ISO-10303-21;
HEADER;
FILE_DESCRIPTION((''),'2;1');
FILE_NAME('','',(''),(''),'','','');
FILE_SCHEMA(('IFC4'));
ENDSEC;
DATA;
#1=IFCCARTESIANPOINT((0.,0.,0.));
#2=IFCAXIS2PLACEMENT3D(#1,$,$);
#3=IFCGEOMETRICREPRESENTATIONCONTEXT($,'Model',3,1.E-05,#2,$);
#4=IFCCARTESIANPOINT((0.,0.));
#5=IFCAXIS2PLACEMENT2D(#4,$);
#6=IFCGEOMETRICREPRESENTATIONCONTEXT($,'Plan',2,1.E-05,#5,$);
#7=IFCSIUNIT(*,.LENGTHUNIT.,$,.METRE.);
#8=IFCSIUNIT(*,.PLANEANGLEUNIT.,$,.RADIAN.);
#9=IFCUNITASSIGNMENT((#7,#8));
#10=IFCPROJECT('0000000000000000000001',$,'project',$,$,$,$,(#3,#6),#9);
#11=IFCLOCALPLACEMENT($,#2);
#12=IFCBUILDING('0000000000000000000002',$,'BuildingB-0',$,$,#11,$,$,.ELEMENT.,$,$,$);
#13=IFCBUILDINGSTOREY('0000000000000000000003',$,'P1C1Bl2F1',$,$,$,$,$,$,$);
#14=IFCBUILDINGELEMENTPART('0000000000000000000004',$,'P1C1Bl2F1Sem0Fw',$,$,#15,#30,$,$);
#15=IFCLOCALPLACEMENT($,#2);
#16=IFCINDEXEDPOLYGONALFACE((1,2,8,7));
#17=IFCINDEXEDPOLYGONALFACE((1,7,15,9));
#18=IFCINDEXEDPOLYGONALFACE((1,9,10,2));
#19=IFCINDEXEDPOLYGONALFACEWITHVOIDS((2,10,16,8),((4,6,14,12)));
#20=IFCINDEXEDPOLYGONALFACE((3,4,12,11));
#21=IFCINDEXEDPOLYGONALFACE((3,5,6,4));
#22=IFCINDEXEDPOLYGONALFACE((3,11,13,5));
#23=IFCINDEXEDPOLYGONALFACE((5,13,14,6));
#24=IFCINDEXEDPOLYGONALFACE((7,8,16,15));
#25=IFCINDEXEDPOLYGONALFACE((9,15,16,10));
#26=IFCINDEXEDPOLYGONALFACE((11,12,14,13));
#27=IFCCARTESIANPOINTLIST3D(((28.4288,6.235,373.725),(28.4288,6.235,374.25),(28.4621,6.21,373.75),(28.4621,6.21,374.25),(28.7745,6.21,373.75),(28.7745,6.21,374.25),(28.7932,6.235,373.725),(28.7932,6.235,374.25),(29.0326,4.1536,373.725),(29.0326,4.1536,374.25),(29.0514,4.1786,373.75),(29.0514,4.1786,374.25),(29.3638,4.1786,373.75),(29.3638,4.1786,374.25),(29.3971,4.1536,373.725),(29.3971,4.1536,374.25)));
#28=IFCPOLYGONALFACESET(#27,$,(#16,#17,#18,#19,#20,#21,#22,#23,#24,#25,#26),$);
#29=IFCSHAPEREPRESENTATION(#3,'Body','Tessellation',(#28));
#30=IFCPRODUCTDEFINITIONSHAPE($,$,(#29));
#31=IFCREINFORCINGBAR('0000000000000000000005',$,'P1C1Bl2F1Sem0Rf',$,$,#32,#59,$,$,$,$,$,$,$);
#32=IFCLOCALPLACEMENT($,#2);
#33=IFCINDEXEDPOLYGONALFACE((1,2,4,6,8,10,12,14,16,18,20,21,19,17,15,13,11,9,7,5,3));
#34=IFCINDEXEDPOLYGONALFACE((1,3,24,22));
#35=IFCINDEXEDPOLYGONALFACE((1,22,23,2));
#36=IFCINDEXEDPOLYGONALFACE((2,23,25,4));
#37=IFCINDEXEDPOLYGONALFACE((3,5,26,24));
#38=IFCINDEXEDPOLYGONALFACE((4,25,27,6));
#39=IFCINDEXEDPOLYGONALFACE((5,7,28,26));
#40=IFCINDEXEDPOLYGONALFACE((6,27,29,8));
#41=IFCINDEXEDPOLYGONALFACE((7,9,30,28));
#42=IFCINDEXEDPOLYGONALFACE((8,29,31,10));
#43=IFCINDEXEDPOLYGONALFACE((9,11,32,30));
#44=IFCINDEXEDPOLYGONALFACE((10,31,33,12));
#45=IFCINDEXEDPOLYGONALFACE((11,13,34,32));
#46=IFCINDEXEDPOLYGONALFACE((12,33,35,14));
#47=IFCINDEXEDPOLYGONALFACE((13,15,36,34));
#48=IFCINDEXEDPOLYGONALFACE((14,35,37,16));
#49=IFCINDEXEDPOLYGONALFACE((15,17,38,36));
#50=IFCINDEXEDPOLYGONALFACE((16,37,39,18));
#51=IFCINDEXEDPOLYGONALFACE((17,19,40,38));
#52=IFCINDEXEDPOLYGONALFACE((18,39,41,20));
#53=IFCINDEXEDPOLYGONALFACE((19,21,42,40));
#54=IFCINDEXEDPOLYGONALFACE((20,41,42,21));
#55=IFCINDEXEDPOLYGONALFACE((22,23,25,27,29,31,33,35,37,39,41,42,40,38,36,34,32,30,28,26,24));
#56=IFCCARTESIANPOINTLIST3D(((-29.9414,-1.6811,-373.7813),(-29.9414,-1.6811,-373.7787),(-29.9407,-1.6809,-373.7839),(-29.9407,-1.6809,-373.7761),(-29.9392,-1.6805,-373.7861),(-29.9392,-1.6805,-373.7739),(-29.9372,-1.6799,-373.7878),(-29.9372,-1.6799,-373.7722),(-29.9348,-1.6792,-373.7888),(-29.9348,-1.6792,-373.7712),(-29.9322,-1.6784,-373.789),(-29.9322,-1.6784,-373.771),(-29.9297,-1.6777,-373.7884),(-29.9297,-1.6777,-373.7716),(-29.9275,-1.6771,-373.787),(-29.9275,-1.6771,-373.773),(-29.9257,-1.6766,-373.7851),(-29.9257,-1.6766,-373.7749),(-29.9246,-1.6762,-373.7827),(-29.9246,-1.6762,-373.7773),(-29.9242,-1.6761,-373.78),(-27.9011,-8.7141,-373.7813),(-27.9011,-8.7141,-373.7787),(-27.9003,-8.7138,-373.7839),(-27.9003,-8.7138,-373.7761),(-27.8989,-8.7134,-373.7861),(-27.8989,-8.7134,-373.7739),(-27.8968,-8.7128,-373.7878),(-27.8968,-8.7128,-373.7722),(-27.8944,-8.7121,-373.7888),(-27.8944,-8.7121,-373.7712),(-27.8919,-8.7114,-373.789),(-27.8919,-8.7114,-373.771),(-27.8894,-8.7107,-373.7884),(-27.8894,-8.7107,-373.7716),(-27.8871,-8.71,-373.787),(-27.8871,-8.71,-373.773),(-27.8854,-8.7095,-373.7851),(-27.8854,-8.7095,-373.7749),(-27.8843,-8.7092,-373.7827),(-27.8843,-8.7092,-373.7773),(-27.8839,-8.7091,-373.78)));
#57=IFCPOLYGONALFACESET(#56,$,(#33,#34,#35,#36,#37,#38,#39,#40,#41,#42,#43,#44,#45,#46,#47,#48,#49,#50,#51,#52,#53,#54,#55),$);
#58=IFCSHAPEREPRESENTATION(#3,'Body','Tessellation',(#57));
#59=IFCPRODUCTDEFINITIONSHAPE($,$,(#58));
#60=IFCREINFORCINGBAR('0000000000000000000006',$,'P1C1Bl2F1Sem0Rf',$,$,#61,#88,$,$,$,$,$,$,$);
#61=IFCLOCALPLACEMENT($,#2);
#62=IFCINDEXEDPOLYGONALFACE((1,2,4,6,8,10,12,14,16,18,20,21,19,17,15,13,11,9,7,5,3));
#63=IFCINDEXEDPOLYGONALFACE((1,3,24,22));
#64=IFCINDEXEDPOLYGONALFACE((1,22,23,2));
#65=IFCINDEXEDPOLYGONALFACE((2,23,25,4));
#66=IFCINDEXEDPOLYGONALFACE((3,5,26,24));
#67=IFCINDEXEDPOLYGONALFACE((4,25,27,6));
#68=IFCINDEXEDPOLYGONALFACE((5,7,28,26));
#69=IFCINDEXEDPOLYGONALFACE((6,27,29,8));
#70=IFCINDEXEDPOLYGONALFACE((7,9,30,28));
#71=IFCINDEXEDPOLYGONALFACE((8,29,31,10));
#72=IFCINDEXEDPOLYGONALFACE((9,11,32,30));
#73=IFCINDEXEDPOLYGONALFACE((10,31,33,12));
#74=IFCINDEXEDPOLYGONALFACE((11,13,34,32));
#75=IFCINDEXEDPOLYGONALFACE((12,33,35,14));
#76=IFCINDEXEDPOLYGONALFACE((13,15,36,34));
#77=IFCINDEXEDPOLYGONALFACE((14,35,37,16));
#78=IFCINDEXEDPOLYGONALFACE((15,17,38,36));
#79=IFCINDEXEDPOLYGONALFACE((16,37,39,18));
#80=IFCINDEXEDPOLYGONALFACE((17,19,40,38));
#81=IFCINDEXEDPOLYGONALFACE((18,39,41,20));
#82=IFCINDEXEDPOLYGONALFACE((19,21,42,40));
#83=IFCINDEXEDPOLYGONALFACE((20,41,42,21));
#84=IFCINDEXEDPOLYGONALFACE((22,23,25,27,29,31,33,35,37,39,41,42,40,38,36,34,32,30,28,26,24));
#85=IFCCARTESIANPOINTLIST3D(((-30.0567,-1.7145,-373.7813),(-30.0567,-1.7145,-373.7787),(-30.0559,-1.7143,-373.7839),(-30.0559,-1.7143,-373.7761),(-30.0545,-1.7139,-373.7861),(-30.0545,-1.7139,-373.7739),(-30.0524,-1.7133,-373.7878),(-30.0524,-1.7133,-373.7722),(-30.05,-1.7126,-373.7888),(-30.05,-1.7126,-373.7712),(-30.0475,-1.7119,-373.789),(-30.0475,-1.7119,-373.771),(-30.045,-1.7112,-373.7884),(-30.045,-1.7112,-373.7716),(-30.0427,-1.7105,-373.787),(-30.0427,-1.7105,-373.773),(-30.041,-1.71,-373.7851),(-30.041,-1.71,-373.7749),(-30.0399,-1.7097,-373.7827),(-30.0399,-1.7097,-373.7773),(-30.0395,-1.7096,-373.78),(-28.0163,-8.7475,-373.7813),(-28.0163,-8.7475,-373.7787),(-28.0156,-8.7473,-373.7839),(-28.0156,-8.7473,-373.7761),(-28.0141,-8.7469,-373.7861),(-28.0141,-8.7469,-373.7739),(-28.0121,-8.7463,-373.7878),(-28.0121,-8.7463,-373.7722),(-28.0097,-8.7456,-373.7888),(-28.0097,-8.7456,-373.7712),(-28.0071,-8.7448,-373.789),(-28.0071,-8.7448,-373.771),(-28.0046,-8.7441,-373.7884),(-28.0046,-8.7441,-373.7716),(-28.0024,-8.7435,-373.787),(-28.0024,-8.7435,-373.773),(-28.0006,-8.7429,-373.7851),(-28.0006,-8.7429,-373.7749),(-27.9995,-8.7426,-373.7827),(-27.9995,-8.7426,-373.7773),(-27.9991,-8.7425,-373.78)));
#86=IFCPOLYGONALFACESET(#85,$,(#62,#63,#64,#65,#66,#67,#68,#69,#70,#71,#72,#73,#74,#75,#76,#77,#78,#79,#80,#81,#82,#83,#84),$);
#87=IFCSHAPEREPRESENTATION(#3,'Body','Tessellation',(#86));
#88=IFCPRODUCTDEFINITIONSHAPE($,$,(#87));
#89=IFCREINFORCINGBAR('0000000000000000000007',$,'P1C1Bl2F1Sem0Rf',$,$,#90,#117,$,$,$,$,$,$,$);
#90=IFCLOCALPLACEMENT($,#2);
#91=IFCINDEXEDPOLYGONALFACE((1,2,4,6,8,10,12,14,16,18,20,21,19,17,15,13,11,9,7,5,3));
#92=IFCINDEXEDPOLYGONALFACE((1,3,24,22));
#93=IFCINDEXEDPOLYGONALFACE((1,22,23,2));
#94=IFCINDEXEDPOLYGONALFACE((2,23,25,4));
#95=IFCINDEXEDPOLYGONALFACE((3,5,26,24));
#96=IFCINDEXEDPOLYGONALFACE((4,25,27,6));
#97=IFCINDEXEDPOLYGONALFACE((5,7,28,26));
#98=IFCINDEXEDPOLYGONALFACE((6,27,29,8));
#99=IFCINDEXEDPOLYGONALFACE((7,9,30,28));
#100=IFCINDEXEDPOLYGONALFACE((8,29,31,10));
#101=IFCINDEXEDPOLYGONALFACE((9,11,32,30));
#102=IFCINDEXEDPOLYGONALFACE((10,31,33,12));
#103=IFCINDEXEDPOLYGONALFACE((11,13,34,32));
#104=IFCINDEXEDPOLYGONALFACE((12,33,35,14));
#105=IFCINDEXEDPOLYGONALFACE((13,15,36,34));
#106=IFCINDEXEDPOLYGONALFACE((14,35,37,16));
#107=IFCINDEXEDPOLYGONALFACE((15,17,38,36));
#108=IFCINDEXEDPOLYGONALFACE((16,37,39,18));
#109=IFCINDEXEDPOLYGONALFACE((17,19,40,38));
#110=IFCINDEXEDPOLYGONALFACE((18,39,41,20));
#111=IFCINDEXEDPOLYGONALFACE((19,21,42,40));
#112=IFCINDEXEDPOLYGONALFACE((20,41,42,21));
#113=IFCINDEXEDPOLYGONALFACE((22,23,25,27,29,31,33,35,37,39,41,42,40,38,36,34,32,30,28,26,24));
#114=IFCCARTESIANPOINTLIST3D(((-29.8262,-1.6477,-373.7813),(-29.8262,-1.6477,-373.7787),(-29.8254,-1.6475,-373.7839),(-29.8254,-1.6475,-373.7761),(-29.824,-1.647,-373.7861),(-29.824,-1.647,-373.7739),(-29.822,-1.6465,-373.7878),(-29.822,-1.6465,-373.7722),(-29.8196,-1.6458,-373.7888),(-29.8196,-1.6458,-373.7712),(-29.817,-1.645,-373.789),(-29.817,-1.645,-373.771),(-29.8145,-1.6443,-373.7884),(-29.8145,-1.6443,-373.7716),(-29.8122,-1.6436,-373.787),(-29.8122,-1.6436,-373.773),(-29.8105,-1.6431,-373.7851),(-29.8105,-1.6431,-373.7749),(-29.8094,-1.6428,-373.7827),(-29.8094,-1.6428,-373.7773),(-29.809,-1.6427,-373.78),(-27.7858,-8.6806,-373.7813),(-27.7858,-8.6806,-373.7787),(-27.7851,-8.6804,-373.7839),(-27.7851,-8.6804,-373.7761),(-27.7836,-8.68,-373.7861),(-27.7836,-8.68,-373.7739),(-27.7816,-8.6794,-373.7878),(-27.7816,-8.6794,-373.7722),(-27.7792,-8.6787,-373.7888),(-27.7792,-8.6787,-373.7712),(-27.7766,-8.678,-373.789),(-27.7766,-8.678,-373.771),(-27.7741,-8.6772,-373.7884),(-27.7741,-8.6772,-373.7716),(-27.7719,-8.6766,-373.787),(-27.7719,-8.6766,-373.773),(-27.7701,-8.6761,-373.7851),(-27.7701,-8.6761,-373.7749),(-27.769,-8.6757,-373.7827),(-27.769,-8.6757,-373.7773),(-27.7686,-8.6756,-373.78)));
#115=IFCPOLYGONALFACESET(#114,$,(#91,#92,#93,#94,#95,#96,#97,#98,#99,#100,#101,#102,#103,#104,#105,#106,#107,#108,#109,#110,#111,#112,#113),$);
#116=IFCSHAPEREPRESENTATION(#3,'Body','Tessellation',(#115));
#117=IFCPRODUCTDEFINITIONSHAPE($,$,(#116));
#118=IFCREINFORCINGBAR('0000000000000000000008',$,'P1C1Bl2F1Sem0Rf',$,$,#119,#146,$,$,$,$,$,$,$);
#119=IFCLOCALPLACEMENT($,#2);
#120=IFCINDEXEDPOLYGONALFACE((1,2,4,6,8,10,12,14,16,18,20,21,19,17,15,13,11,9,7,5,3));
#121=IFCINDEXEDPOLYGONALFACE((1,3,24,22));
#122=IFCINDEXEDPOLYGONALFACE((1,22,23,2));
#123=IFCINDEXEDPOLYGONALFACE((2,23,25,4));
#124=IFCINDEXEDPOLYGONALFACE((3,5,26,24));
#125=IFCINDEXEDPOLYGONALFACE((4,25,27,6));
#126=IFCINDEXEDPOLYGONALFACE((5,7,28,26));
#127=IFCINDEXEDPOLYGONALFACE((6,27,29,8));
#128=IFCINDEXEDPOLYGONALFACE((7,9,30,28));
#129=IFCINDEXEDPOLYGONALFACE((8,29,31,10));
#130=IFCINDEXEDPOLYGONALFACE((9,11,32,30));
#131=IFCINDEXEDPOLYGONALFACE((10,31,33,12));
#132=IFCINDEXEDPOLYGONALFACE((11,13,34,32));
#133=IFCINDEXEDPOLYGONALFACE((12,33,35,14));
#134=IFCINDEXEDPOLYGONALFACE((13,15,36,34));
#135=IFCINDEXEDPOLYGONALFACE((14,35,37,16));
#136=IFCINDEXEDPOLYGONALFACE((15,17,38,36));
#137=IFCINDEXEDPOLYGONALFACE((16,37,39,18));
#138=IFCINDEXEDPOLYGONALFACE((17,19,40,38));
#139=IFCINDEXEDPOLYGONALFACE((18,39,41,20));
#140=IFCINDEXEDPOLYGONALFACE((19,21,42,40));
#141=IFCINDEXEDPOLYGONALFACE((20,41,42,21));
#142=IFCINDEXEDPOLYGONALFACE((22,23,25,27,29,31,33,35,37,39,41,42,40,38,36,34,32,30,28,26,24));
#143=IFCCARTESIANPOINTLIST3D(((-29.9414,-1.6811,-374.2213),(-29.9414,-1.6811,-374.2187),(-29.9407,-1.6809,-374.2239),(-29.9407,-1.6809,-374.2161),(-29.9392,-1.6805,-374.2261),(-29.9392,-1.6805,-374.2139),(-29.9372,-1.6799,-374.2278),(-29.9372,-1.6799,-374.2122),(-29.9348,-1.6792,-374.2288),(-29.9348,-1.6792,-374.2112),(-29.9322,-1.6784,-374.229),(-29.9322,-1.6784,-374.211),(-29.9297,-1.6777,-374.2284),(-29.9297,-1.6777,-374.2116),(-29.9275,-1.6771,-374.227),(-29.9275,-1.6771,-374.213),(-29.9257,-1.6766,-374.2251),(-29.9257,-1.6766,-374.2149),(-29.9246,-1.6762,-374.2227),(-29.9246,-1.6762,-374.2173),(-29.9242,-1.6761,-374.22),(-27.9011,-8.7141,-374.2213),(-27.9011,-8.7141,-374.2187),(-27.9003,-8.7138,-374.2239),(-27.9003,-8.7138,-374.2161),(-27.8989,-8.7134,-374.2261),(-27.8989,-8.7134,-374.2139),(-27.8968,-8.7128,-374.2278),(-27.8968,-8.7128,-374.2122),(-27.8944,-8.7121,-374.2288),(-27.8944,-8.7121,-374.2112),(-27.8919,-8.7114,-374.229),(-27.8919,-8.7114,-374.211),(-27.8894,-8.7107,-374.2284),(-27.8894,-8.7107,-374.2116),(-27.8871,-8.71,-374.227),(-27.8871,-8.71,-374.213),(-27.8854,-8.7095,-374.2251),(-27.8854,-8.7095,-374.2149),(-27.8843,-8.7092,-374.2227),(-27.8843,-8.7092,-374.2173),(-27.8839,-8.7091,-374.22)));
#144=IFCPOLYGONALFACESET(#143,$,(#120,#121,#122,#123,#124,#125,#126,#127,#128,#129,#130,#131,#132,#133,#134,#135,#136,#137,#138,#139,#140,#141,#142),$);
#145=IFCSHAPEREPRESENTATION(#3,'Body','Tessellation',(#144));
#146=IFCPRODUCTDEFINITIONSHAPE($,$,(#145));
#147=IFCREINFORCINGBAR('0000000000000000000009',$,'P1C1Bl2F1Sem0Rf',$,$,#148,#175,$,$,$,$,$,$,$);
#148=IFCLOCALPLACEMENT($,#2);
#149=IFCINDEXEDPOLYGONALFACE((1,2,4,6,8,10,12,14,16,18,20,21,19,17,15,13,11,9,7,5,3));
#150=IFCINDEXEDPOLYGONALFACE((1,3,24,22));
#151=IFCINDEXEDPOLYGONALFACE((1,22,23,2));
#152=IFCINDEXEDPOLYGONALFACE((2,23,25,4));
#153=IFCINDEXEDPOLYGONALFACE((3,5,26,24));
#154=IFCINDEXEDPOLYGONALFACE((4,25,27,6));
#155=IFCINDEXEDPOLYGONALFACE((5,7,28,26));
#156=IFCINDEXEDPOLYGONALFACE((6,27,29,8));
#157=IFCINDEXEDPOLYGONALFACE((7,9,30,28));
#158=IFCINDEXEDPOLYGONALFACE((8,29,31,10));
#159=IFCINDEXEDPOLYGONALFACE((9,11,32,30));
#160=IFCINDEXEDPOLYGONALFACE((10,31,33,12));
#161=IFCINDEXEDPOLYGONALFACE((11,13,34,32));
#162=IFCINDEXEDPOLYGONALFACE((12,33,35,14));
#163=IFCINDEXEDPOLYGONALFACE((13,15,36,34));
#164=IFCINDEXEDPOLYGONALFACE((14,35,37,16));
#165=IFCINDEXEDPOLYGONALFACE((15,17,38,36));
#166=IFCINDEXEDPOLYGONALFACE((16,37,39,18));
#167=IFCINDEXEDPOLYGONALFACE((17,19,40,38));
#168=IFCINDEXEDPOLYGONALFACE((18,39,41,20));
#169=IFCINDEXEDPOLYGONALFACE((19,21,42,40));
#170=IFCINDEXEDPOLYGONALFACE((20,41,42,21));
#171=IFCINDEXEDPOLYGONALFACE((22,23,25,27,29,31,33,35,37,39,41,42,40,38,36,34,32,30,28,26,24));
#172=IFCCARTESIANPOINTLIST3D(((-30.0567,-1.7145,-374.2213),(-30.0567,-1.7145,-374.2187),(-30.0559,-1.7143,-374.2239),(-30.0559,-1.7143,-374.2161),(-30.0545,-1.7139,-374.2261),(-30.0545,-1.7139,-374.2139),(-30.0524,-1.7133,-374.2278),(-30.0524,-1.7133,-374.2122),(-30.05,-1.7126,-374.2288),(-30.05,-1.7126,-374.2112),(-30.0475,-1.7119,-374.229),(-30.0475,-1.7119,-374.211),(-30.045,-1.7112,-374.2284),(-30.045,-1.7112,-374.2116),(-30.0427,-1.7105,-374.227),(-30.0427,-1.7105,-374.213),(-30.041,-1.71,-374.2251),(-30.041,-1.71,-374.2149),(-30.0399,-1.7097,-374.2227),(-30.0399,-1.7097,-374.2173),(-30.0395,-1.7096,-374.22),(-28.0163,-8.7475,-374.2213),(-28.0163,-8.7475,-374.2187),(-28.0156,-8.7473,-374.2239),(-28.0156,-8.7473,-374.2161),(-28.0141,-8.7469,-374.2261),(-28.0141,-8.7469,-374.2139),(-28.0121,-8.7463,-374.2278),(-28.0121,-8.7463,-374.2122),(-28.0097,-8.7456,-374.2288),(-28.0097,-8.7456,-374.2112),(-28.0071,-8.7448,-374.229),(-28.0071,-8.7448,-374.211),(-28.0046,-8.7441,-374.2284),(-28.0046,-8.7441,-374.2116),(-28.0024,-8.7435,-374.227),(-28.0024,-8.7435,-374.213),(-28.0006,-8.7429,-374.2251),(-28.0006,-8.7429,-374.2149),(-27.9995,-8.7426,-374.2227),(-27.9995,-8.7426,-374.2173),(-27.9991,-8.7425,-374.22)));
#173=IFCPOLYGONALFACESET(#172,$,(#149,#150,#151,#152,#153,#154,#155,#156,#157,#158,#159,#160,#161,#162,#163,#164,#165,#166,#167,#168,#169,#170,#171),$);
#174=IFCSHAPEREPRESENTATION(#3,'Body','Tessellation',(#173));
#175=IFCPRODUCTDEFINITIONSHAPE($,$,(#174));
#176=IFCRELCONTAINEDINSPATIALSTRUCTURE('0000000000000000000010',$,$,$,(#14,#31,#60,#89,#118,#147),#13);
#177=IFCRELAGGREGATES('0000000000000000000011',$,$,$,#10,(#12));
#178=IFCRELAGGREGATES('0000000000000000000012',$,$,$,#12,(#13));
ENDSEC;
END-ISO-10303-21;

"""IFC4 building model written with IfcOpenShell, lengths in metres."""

from ifc_helpers import new_model, entity, si_unit, origin, origin_2d, place, context, project, spatial, polyline, outline, extrude, element, save


model = new_model("IFC4")

# Units and contexts
model_context = context("Model", 3, precision=1e-05, world=origin())
plan_context = context("Plan", 2, precision=1e-05, world=origin_2d())
ifc_project = project(units=[si_unit("LENGTHUNIT", "METRE"), si_unit("PLANEANGLEUNIT", "RADIAN")], contexts=[model_context, plan_context])

# Building, storey
building_placement = place(None, origin())
building = spatial("IfcBuilding", under=ifc_project, at=building_placement, Name="BuildingB-0", CompositionType="ELEMENT")
storey = spatial("IfcBuildingStorey", under=building, Name="P1C1Bl2F1")

# Building element part, opening
building_element_part_1 = element("IfcBuildingElementPart", 1, inside=storey, Name="P1C1Bl2F1Sem0Fw", context=model_context, shape_type="SweptSolid", body=[
    extrude(outline(polyline([(29.0326, 4.1536, 373.725), (29.3971, 4.1536, 373.725), (28.7932, 6.235, 373.725), (28.4288, 6.235, 373.725), (29.0326, 4.1536, 373.725)])), None, (0.0, 0.0, 1.0), 0.525),
])
element("IfcOpeningElement", 2, inside=storey, cuts=building_element_part_1, context=model_context, shape_type="SweptSolid", body=[
    extrude(outline(polyline([(29.0514, 4.1786, 373.75), (29.3638, 4.1786, 373.75), (28.7745, 6.21, 373.75), (28.4621, 6.21, 373.75), (29.0514, 4.1786, 373.75)])), None, (0.0, 0.0, 1.0), 0.5),
])

# Reinforcing bars
element("IfcReinforcingBar", 3, inside=storey, Name="P1C1Bl2F1Sem0Rf", context=model_context, shape_type="SweptSolid", body=[
    entity("IfcSurfaceCurveSweptAreaSolid", entity("IfcCircleProfileDef", "AREA", None, None, 0.009), None, entity("IfcPolyline", [entity("IfcCartesianPoint", [29.9329, 1.6786, 373.78]), entity("IfcCartesianPoint", [27.8925, 8.7116, 373.78])]), None, None, entity("IfcPlane", entity("IfcAxis2Placement3D", entity("IfcCartesianPoint", [29.9329, 1.6786, 373.78]), entity("IfcDirection", [0.0, 0.0, 1.0]), entity("IfcDirection", [1.0, 0.0, 0.0])))),
])
element("IfcReinforcingBar", 4, inside=storey, Name="P1C1Bl2F1Sem0Rf", context=model_context, shape_type="SweptSolid", body=[
    entity("IfcSurfaceCurveSweptAreaSolid", entity("IfcCircleProfileDef", "AREA", None, None, 0.009), None, entity("IfcPolyline", [entity("IfcCartesianPoint", [30.0481, 1.7121, 373.78]), entity("IfcCartesianPoint", [28.0078, 8.745, 373.78])]), None, None, entity("IfcPlane", entity("IfcAxis2Placement3D", entity("IfcCartesianPoint", [30.0481, 1.7121, 373.78]), entity("IfcDirection", [0.0, 0.0, 1.0]), entity("IfcDirection", [1.0, 0.0, 0.0])))),
])
element("IfcReinforcingBar", 5, inside=storey, Name="P1C1Bl2F1Sem0Rf", context=model_context, shape_type="SweptSolid", body=[
    entity("IfcSurfaceCurveSweptAreaSolid", entity("IfcCircleProfileDef", "AREA", None, None, 0.009), None, entity("IfcPolyline", [entity("IfcCartesianPoint", [29.8176, 1.6452, 373.78]), entity("IfcCartesianPoint", [27.7773, 8.6781, 373.78])]), None, None, entity("IfcPlane", entity("IfcAxis2Placement3D", entity("IfcCartesianPoint", [29.8176, 1.6452, 373.78]), entity("IfcDirection", [0.0, 0.0, 1.0]), entity("IfcDirection", [1.0, 0.0, 0.0])))),
])
element("IfcReinforcingBar", 6, inside=storey, Name="P1C1Bl2F1Sem0Rf", context=model_context, shape_type="SweptSolid", body=[
    entity("IfcSurfaceCurveSweptAreaSolid", entity("IfcCircleProfileDef", "AREA", None, None, 0.009), None, entity("IfcPolyline", [entity("IfcCartesianPoint", [29.9329, 1.6786, 374.22]), entity("IfcCartesianPoint", [27.8925, 8.7116, 374.22])]), None, None, entity("IfcPlane", entity("IfcAxis2Placement3D", entity("IfcCartesianPoint", [29.9329, 1.6786, 374.22]), entity("IfcDirection", [0.0, 0.0, 1.0]), entity("IfcDirection", [1.0, 0.0, 0.0])))),
])
element("IfcReinforcingBar", 7, inside=storey, Name="P1C1Bl2F1Sem0Rf", context=model_context, shape_type="SweptSolid", body=[
    entity("IfcSurfaceCurveSweptAreaSolid", entity("IfcCircleProfileDef", "AREA", None, None, 0.009), None, entity("IfcPolyline", [entity("IfcCartesianPoint", [30.0481, 1.7121, 374.22]), entity("IfcCartesianPoint", [28.0078, 8.745, 374.22])]), None, None, entity("IfcPlane", entity("IfcAxis2Placement3D", entity("IfcCartesianPoint", [30.0481, 1.7121, 374.22]), entity("IfcDirection", [0.0, 0.0, 1.0]), entity("IfcDirection", [1.0, 0.0, 0.0])))),
])

save(model, "model.ifc")
